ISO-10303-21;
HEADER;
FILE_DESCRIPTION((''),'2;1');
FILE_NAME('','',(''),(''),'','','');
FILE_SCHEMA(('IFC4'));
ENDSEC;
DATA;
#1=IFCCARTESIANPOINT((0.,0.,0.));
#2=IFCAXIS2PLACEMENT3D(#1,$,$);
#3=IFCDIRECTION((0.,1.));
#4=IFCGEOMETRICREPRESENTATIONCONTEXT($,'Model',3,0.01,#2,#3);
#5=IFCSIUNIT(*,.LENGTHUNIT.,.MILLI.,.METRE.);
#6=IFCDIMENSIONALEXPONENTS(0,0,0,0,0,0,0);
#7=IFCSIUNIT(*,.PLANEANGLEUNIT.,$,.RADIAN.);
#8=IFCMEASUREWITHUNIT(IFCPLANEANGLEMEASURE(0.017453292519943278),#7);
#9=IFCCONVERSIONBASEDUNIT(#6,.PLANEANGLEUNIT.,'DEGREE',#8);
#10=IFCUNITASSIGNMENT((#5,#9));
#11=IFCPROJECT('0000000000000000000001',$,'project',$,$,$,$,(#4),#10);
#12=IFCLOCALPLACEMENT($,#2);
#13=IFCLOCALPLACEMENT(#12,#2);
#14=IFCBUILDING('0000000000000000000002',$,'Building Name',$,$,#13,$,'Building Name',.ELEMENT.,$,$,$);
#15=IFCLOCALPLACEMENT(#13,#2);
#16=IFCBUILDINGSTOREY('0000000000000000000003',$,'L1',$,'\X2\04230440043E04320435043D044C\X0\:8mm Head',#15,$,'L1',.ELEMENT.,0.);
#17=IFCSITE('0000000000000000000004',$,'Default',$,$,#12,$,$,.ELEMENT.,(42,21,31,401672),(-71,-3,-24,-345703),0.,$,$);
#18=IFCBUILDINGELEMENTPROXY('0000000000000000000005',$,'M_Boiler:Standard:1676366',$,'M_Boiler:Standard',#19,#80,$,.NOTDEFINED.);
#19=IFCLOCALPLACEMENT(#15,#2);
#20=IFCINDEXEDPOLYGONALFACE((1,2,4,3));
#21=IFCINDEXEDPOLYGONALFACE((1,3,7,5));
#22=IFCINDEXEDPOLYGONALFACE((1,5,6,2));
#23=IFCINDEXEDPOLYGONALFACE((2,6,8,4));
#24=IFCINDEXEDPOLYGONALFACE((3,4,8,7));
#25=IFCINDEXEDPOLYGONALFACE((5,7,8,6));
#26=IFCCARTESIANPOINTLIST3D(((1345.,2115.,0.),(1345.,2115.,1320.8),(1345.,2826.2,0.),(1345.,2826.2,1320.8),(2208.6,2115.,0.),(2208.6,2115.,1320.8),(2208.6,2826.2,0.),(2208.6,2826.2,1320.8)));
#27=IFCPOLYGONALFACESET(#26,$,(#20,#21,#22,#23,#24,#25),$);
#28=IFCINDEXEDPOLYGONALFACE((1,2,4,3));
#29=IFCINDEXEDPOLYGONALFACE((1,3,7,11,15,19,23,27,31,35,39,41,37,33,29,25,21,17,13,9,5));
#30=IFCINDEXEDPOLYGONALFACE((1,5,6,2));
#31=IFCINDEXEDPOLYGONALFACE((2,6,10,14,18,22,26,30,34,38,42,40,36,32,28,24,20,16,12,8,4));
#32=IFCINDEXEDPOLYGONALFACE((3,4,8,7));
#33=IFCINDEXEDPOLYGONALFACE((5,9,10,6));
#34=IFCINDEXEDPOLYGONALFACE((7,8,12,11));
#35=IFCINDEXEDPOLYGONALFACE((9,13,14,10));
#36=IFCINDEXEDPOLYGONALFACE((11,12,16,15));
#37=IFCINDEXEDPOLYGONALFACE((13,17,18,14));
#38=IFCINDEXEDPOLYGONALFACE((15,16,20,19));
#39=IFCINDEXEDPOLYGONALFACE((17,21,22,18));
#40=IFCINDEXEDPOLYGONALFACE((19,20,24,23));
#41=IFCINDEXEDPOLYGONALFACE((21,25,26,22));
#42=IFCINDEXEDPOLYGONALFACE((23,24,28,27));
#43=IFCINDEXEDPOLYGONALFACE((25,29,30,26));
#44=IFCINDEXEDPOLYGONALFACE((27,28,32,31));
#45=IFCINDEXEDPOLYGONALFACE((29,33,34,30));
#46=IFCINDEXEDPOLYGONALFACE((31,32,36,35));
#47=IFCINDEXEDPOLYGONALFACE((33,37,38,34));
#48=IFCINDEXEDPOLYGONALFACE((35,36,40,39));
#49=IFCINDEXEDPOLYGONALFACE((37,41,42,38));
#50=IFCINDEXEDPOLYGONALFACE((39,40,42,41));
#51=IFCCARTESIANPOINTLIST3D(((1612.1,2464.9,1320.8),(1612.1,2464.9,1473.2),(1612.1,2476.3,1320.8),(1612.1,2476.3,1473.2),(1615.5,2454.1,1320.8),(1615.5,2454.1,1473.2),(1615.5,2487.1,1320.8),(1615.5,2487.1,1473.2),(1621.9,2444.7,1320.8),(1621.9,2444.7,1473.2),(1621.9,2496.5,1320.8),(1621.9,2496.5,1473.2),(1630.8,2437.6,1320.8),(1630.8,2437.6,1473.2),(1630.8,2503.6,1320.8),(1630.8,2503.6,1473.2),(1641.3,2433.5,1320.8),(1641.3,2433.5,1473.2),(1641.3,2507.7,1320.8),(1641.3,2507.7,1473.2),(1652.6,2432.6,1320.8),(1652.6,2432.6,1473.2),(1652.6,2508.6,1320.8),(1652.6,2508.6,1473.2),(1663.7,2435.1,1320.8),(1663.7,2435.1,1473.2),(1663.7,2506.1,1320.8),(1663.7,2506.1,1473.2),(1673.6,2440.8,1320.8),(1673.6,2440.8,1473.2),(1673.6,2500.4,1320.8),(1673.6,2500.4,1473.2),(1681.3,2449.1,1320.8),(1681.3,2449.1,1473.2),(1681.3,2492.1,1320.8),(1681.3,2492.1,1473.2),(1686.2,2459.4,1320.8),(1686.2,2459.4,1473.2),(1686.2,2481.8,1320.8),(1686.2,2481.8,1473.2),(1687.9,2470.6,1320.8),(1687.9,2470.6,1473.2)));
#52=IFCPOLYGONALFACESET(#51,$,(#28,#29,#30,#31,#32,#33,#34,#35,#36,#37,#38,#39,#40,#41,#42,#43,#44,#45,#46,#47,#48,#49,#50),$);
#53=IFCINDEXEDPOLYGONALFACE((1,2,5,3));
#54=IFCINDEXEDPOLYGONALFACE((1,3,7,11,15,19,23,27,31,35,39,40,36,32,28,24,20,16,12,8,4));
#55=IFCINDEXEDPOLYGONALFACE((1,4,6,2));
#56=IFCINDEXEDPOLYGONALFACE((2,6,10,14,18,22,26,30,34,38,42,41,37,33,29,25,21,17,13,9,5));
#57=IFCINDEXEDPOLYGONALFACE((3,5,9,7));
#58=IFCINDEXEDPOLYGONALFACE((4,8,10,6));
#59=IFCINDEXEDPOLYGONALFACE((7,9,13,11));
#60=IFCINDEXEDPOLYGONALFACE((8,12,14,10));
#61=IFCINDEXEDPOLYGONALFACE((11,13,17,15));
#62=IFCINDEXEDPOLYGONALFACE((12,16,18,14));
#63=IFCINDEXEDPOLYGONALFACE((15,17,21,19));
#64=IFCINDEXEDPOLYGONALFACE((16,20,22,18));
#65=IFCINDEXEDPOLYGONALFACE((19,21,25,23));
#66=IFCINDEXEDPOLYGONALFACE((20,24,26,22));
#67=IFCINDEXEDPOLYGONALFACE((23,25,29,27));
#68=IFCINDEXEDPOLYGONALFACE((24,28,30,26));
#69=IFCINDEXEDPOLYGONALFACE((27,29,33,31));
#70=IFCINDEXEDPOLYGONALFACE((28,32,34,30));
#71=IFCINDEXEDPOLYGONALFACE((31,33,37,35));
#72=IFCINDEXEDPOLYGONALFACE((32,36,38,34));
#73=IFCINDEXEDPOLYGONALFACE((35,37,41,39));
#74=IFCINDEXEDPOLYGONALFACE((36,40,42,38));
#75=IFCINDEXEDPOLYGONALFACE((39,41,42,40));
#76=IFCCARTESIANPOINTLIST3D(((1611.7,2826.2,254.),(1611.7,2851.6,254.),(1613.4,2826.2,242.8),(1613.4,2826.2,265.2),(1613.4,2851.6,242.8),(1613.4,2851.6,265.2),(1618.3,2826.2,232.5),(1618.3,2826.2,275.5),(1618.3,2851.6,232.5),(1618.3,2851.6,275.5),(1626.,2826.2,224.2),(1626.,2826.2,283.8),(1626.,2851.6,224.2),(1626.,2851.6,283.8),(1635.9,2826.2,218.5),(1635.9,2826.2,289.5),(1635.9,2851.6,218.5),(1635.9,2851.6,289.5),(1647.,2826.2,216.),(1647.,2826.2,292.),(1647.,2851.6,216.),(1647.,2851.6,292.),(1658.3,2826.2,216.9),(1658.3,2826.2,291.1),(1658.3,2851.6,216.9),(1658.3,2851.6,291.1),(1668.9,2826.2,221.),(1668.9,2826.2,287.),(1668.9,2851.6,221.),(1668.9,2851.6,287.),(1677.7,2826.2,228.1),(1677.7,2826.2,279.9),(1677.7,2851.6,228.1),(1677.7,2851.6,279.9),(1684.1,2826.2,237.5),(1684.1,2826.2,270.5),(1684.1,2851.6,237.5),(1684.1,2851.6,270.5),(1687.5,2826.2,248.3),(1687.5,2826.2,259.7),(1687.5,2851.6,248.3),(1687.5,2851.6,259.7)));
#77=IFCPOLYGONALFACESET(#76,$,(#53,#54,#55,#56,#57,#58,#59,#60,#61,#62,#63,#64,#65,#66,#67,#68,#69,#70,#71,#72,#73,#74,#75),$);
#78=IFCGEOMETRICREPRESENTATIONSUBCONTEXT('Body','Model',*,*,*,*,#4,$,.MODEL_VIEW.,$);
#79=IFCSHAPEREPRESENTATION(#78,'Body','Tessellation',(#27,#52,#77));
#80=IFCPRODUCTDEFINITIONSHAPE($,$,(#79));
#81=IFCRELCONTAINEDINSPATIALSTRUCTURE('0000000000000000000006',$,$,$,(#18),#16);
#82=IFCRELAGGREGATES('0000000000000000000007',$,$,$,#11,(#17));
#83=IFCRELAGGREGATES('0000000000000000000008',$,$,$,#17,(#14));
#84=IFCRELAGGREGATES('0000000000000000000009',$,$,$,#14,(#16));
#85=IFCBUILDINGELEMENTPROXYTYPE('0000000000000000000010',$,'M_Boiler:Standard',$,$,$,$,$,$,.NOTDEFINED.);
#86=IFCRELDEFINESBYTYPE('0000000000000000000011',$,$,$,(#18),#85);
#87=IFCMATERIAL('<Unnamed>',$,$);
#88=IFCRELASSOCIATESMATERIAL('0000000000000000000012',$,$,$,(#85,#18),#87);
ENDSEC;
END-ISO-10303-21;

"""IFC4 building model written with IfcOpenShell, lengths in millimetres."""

from ifc_helpers import new_model, entity, si_unit, converted_unit, direction, frame, frame_2d, origin, place, context, subcontext, project, spatial, rectangle, circle, extrude, source, transform, mapped, material, type_object, type_shapes, element, save


model = new_model("IFC4")

# Units and contexts
model_context = context("Model", 3, precision=0.01, world=origin(), true_north=direction((0.0, 1.0)))
body_context = subcontext(model_context, "Body", "Model", "MODEL_VIEW")
ifc_project = project(units=[si_unit("LENGTHUNIT", "METRE", prefix="MILLI"), converted_unit("PLANEANGLEUNIT", "DEGREE", entity("IfcPlaneAngleMeasure", 0.017453292519943278), si_unit("PLANEANGLEUNIT", "RADIAN"), dimensions=[0, 0, 0, 0, 0, 0, 0])], contexts=[model_context])

# Site, building, storey
site_placement = place(None, origin())
site = spatial("IfcSite", under=ifc_project, at=site_placement, Name="Default", CompositionType="ELEMENT", RefLatitude=(42, 21, 31, 401672), RefLongitude=(-71, -3, -24, -345703), RefElevation=0.0)
building_placement = place(site_placement, origin())
building = spatial("IfcBuilding", under=site, at=building_placement, Name="Building Name", LongName="Building Name", CompositionType="ELEMENT")
storey_placement = place(building_placement, origin())
storey = spatial("IfcBuildingStorey", under=building, at=storey_placement, Name="L1", ObjectType="Уровень:8mm Head", LongName="L1", CompositionType="ELEMENT", Elevation=0.0)

# Building element proxy
ifc_material_1 = material(Name="<Unnamed>")
building_element_proxy_type_1 = type_object("IfcBuildingElementProxyType", Name="M_Boiler:Standard", PredefinedType="NOTDEFINED", material=ifc_material_1)
shared_shape_1 = source(origin(), body_context, "Body", "SweptSolid", [
    extrude(rectangle(XDim=711.2, YDim=863.6, at=frame_2d((0.0, 0.0), x_axis=(1.0, 0.0))), frame((431.8, 355.6, 0.0), z_axis=(0.0, 0.0, 1.0), x_axis=(0.0, 1.0, 0.0)), (0.0, 0.0, 1.0), 1320.8),
    extrude(circle(Radius=38.1, at=frame_2d((0.0, 0.0), x_axis=(1.0, 0.0))), frame((304.8, 355.6, 1320.8)), (0.0, 0.0, 1.0), 152.4),
    extrude(circle(Radius=38.1, at=frame_2d((0.0, 0.0), x_axis=(1.0, 0.0))), frame((304.8, 711.2, 254.0), z_axis=(0.0, 1.0, 0.0), x_axis=(-1.0, 0.0, 0.0)), (0.0, 0.0, 1.0), 25.4),
])
type_shapes(building_element_proxy_type_1, [shared_shape_1])
proxy_1_placement = place(storey_placement, frame((1345.0, 2115.0, 0.0)))
element("IfcBuildingElementProxy", 1, at=proxy_1_placement, inside=storey, type_object=building_element_proxy_type_1, material=ifc_material_1, Name="M_Boiler:Standard:1676366", ObjectType="M_Boiler:Standard", PredefinedType="NOTDEFINED", context=body_context, shape_type="MappedRepresentation", body=[
    mapped(shared_shape_1, transform((0.0, 0.0, 0.0), scale=1.0)),
])

save(model, "model.ifc")
